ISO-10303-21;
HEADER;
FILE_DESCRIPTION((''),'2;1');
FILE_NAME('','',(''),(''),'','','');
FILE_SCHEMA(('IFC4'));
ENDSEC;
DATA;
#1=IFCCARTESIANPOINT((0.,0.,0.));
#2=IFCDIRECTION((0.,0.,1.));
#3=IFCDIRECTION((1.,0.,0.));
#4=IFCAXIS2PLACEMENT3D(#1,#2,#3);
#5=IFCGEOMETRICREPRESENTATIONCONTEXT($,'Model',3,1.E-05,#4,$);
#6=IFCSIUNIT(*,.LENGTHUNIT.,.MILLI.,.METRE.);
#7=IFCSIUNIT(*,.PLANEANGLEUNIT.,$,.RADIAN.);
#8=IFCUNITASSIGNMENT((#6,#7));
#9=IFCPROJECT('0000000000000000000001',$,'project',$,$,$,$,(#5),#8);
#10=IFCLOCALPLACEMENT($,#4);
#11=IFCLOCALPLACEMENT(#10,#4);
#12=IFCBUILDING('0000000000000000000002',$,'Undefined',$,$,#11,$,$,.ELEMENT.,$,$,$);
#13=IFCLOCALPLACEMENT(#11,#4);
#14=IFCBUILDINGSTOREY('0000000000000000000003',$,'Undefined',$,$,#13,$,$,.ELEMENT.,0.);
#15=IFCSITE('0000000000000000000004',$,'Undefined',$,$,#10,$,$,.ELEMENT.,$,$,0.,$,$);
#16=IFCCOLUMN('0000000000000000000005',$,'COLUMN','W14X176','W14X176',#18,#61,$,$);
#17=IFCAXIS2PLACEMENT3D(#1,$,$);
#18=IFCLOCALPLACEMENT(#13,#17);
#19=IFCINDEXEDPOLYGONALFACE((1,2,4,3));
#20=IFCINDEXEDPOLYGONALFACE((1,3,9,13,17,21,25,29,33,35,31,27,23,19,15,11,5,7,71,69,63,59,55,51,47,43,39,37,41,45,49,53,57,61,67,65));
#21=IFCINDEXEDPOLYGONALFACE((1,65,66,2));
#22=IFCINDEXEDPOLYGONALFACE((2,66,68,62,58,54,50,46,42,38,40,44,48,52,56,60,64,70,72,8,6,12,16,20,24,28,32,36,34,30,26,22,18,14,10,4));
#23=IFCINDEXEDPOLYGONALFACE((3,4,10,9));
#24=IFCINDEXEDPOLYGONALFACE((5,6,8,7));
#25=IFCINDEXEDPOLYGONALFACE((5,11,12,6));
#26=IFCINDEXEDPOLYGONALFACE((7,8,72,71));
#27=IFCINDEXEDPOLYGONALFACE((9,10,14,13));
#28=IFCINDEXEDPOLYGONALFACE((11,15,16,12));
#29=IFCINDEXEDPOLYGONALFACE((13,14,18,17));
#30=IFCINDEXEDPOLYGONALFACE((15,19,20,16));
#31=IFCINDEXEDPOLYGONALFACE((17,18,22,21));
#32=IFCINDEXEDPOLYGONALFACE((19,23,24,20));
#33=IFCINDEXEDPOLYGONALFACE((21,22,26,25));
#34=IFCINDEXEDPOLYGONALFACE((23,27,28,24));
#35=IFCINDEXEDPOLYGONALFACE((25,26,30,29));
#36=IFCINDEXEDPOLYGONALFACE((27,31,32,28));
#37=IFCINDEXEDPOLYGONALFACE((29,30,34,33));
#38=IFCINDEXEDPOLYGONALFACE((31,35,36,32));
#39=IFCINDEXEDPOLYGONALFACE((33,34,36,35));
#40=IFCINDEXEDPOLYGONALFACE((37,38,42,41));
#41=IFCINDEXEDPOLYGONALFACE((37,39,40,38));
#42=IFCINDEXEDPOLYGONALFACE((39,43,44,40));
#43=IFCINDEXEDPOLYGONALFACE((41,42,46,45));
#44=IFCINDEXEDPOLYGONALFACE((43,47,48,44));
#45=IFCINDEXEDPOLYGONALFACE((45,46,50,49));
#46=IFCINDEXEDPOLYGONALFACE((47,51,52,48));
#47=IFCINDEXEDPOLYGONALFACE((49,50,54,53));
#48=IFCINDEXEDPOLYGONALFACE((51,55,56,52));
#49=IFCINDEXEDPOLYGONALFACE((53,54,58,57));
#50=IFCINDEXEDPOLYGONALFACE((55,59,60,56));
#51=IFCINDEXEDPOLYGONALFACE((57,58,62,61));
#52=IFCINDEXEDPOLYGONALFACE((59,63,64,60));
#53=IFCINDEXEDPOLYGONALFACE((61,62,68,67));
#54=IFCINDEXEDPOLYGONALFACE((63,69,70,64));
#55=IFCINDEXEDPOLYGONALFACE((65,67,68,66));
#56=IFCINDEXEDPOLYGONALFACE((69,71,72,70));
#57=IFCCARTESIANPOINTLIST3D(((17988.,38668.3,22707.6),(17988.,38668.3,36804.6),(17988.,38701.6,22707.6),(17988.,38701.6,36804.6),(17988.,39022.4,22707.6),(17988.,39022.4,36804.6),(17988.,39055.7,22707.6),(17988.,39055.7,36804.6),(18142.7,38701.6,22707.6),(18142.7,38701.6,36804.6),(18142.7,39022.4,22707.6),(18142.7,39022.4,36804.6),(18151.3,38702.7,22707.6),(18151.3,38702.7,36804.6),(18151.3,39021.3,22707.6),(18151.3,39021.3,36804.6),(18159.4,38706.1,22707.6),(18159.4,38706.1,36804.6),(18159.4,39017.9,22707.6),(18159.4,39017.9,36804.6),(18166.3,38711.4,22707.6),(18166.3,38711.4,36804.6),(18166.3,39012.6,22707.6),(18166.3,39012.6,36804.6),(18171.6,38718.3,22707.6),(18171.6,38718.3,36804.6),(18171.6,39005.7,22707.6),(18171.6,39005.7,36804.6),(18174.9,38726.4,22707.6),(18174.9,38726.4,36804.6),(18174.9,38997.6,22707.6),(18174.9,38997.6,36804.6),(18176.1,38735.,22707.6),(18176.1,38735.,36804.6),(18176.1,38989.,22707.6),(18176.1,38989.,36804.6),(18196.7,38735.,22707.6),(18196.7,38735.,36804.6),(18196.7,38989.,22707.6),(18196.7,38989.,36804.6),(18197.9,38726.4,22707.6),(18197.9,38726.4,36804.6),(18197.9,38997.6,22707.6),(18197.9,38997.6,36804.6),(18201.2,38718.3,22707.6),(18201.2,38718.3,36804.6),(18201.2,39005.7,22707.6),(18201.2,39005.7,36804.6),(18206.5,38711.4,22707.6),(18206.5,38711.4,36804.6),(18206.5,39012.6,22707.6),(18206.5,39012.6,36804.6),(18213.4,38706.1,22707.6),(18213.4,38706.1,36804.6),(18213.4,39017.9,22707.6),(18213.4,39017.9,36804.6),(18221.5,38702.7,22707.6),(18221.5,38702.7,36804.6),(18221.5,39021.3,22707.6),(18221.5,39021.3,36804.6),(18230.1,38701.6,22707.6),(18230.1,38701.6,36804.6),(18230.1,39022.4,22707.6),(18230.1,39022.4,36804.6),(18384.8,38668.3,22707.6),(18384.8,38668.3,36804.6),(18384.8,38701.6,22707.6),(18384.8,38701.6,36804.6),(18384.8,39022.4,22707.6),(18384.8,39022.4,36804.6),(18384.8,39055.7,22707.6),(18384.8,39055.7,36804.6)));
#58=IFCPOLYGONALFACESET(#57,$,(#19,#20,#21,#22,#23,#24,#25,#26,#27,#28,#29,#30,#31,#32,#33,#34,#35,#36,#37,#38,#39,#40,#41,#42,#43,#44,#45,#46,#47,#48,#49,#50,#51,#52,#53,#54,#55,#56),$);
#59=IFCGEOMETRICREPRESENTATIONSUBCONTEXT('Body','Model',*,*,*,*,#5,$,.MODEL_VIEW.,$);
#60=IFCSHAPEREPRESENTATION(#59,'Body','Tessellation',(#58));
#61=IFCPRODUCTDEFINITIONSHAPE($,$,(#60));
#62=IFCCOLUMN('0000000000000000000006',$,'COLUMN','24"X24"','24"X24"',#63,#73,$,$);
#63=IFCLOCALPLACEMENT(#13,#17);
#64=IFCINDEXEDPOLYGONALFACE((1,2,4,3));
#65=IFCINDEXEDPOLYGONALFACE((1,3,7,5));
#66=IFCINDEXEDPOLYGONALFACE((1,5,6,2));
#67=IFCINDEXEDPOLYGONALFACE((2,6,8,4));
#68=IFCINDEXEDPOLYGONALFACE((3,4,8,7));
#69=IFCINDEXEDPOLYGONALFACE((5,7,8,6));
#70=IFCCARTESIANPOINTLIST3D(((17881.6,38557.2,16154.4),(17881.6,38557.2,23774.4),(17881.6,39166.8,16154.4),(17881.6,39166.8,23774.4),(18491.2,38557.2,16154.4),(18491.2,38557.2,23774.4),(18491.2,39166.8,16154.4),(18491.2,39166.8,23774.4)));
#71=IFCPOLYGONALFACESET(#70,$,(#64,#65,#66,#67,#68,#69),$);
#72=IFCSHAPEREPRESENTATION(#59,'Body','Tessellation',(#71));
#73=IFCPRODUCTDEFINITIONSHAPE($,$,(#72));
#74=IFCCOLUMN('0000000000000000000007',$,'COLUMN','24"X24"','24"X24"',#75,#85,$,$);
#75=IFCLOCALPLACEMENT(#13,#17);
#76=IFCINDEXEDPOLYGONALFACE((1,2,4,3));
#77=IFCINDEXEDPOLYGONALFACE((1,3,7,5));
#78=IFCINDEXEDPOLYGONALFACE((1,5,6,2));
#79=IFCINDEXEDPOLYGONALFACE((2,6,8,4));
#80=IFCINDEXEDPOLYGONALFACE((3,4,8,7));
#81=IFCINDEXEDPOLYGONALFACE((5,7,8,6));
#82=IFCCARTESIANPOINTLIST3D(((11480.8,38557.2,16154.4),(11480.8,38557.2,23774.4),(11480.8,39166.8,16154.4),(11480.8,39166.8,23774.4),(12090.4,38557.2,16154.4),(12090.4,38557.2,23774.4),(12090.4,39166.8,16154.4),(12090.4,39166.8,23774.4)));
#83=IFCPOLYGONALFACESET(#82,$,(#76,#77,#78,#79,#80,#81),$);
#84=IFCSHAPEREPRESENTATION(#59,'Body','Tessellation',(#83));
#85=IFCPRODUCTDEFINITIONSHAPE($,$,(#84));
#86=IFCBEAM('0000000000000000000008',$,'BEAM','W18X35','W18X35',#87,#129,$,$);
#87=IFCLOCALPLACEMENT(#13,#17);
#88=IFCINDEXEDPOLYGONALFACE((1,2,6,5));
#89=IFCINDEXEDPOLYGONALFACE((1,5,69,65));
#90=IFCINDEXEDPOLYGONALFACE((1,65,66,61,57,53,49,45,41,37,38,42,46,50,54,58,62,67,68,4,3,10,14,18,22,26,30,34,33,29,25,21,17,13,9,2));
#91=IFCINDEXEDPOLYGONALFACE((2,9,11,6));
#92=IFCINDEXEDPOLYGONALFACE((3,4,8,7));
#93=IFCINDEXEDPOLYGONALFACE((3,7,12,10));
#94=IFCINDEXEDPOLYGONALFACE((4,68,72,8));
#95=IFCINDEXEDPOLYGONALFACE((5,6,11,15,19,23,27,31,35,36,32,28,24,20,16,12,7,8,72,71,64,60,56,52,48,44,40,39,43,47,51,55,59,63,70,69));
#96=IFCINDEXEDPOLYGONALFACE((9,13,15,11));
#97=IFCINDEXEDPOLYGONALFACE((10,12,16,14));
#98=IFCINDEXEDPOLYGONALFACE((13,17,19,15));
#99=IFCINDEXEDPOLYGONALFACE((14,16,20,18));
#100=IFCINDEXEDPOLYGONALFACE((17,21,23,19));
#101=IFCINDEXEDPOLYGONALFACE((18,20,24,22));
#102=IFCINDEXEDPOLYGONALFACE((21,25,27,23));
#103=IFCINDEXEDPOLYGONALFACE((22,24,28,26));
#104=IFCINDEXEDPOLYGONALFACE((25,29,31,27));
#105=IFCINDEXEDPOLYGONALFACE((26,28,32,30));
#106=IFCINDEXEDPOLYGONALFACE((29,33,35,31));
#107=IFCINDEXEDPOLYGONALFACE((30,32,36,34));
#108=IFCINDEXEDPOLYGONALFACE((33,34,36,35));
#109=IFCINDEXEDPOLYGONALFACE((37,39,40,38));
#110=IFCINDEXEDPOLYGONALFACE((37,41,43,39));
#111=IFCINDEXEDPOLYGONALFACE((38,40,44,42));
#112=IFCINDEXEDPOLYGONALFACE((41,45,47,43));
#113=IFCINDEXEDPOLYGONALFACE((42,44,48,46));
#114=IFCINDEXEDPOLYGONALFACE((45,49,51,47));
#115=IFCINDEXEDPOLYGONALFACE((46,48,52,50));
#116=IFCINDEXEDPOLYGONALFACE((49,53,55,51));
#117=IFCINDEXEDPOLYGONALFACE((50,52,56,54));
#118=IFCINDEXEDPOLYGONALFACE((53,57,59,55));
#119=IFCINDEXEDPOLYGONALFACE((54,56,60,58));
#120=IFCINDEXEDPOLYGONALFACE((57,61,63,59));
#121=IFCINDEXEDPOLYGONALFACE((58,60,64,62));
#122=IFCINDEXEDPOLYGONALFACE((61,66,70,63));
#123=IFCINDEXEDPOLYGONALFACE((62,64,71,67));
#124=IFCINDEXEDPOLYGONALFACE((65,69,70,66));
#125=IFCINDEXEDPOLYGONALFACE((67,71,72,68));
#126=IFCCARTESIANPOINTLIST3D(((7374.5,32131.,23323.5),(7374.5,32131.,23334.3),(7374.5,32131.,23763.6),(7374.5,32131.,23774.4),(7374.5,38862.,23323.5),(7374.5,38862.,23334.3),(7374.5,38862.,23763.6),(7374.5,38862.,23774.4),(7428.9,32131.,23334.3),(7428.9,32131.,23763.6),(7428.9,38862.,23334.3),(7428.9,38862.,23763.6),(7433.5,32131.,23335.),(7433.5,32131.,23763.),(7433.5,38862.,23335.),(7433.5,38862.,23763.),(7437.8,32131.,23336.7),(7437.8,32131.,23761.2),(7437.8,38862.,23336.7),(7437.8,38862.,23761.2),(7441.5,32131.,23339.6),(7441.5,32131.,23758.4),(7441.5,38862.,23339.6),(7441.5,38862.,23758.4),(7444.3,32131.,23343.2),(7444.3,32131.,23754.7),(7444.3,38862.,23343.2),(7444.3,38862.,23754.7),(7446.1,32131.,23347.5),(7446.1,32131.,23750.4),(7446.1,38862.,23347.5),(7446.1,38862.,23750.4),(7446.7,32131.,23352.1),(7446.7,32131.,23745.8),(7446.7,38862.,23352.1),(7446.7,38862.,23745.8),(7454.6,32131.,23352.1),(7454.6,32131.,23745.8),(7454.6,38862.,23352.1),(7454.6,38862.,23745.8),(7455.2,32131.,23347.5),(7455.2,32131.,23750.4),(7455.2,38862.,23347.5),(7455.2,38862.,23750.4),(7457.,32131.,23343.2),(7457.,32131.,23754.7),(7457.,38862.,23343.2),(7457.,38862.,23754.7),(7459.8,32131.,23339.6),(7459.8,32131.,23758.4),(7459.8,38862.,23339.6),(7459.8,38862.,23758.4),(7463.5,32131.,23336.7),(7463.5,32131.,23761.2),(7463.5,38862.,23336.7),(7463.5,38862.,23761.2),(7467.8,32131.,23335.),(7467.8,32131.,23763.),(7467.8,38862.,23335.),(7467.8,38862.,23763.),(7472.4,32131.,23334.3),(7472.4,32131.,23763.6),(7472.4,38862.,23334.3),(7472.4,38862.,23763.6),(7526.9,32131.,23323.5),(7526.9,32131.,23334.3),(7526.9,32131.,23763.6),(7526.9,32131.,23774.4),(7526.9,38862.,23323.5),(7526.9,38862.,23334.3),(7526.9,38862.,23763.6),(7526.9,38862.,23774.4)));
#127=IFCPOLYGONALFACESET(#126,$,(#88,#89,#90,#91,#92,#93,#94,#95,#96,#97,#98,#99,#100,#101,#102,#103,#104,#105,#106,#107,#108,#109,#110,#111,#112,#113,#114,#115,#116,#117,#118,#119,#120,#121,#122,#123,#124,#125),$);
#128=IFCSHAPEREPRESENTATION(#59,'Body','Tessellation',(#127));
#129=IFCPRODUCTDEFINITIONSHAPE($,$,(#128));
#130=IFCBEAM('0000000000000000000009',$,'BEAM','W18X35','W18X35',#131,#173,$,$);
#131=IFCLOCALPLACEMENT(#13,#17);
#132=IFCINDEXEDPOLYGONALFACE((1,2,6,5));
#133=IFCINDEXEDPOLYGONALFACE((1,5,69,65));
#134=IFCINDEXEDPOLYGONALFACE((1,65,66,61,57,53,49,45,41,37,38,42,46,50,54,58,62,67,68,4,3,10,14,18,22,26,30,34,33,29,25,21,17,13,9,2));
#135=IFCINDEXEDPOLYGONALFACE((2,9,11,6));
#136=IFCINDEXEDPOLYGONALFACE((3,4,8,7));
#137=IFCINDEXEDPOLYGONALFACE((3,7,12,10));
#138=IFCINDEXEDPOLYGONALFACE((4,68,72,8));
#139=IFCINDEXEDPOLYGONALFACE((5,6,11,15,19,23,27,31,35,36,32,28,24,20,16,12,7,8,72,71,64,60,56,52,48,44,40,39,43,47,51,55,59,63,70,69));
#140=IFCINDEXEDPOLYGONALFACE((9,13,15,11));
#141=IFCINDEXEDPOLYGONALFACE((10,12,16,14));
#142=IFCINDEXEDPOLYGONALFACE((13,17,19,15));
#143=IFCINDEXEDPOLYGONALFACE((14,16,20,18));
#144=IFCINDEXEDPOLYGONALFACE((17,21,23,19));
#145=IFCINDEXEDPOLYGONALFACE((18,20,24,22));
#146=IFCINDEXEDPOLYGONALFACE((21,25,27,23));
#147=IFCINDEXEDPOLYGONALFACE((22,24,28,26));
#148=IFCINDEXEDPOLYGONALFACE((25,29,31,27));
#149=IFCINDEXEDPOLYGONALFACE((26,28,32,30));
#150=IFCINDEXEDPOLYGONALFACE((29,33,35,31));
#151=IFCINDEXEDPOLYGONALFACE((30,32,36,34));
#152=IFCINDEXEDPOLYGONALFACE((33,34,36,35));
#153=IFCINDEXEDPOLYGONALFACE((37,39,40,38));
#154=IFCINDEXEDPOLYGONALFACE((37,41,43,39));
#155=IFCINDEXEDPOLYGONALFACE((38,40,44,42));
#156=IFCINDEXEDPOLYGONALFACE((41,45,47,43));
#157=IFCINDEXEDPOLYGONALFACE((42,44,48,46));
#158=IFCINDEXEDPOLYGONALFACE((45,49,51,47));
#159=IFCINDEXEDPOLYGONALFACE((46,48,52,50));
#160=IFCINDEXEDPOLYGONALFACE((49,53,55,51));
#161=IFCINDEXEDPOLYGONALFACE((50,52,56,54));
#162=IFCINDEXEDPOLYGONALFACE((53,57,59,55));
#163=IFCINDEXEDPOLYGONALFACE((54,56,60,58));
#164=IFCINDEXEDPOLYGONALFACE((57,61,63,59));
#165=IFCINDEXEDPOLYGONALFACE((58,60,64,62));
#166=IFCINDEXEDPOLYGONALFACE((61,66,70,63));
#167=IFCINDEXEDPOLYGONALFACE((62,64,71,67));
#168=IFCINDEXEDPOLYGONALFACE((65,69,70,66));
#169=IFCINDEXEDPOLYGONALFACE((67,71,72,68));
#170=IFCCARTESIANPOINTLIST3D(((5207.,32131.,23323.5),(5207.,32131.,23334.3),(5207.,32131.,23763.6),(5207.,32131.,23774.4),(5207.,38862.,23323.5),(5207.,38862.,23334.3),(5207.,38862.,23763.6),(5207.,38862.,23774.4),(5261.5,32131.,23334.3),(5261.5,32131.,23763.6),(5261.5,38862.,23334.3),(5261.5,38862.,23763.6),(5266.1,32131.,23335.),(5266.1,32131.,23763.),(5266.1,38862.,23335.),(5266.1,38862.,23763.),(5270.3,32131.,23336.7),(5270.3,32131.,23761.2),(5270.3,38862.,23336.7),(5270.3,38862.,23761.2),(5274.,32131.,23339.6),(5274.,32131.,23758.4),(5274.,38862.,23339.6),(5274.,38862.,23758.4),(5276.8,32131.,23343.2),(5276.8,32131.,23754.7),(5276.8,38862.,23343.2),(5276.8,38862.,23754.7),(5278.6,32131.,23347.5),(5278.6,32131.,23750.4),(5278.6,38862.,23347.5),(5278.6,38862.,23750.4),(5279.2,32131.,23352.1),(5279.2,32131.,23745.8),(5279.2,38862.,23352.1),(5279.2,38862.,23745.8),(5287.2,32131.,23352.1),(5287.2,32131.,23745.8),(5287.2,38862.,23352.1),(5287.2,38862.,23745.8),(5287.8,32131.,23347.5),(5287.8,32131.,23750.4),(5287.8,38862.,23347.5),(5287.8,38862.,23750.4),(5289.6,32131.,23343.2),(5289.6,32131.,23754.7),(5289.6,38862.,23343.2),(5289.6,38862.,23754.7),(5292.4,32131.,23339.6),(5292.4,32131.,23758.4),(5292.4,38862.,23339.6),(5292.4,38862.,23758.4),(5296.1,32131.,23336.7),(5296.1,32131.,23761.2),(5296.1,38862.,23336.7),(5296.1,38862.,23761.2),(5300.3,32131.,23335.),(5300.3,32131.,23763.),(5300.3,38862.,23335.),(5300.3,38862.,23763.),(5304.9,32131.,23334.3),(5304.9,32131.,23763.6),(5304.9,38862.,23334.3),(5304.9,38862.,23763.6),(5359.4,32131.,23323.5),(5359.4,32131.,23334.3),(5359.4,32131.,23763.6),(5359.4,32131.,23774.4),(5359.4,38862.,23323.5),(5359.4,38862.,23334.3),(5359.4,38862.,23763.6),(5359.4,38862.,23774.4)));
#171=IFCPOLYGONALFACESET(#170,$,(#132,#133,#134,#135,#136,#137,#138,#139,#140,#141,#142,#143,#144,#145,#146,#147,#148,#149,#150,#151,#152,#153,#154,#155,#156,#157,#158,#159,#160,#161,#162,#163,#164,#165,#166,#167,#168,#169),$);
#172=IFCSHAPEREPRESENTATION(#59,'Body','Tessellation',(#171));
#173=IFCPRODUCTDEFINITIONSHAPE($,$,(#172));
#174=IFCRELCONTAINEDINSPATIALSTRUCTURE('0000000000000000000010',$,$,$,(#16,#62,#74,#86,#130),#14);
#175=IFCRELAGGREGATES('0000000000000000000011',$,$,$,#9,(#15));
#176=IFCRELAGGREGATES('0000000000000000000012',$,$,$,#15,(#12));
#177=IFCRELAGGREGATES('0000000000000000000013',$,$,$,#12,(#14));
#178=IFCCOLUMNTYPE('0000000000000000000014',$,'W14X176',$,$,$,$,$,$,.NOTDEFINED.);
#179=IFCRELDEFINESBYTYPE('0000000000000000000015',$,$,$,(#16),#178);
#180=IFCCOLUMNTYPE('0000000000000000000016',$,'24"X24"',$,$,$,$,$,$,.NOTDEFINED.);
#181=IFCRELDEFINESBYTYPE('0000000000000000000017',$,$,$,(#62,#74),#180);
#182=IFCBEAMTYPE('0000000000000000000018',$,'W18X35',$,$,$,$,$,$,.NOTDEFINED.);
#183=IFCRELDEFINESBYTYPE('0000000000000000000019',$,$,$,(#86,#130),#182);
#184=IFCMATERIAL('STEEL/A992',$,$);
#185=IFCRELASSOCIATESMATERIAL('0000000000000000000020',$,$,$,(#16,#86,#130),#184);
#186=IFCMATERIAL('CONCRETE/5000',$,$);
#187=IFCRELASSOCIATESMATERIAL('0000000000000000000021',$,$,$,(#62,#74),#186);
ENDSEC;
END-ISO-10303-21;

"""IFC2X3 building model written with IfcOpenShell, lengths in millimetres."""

from ifc_helpers import new_model, si_unit, frame, origin_with_axes, origin_2d_with_axis, place, context, subcontext, project, spatial, rectangle, i_section, extrude, material, type_object, element, save


model = new_model("IFC2X3")

# Units and contexts
model_context = context("Model", 3, precision=1e-05, world=origin_with_axes())
body_context = subcontext(model_context, "Body", "Model", "MODEL_VIEW")
ifc_project = project(units=[si_unit("LENGTHUNIT", "METRE", prefix="MILLI"), si_unit("PLANEANGLEUNIT", "RADIAN")], contexts=[model_context])

# Site, building, storey
site_placement = place(None, origin_with_axes())
site = spatial("IfcSite", under=ifc_project, at=site_placement, Name="Undefined", CompositionType="ELEMENT", RefElevation=0.0)
building_placement = place(site_placement, origin_with_axes())
building = spatial("IfcBuilding", under=site, at=building_placement, Name="Undefined", CompositionType="ELEMENT")
storey_placement = place(building_placement, origin_with_axes())
storey = spatial("IfcBuildingStorey", under=building, at=storey_placement, Name="Undefined", CompositionType="ELEMENT", Elevation=0.0)

# Columns
ifc_material_1 = material(Name="STEEL/A992")
column_type_1 = type_object("IfcColumnType", Name="W14X176", PredefinedType="NOTDEFINED")
column_1_placement = place(storey_placement, frame((18186.4, 38862.0, 22707.6), z_axis=(0.0, 0.0, 1.0), x_axis=(1.0, 0.0, 0.0)))
element("IfcColumn", 1, at=column_1_placement, inside=storey, type_object=column_type_1, material=ifc_material_1, Name="COLUMN", Description="W14X176", ObjectType="W14X176", context=body_context, shape_type="SweptSolid", body=[
    extrude(i_section(OverallWidth=396.9, OverallDepth=387.4, WebThickness=20.6, FlangeThickness=33.3, FilletRadius=33.4, at=origin_2d_with_axis()), frame((0.0, 0.0, 14097.0), z_axis=(0.0, 0.0, -1.0), x_axis=(-1.0, 0.0, 0.0)), (0.0, 0.0, 1.0), 14097.0),
])
ifc_material_2 = material(Name="CONCRETE/5000")
column_type_2 = type_object("IfcColumnType", Name="24\"X24\"", PredefinedType="NOTDEFINED")
for number, where, z_axis, x_axis, name in (
    (2, (18186.4, 38862.0, 16154.4), (0.0, 0.0, 1.0), (1.0, 0.0, 0.0), "COLUMN"),
    (3, (11785.6, 38862.0, 16154.4), (0.0, 0.0, 1.0), (1.0, 0.0, 0.0), "COLUMN"),
):
    element("IfcColumn", number, at=place(storey_placement, frame(where, z_axis=z_axis, x_axis=x_axis)), inside=storey, type_object=column_type_2, material=ifc_material_2, Name=name, Description="24\"X24\"", ObjectType="24\"X24\"", context=body_context, shape_type="SweptSolid", body=[
        extrude(rectangle(XDim=609.6, YDim=609.6, at=origin_2d_with_axis()), frame((0.0, 0.0, 7620.0), z_axis=(0.0, 0.0, -1.0), x_axis=(0.0, -1.0, 0.0)), (0.0, 0.0, 1.0), 7620.0),
    ])

# Beams
beam_type_1 = type_object("IfcBeamType", Name="W18X35", PredefinedType="NOTDEFINED")
for number, where, z_axis, x_axis, name in (
    (4, (7450.7, 32131.0, 23549.0), (0.0, 0.0, 1.0), (0.0, 1.0, 0.0), "BEAM"),
    (5, (5283.2, 32131.0, 23549.0), (0.0, 0.0, 1.0), (0.0, 1.0, 0.0), "BEAM"),
):
    element("IfcBeam", number, at=place(storey_placement, frame(where, z_axis=z_axis, x_axis=x_axis)), inside=storey, type_object=beam_type_1, material=ifc_material_1, Name=name, Description="W18X35", ObjectType="W18X35", context=body_context, shape_type="SweptSolid", body=[
        extrude(i_section(OverallWidth=152.4, OverallDepth=450.9, WebThickness=7.9, FlangeThickness=10.8, FilletRadius=17.8, at=origin_2d_with_axis()), frame((6731.0, 0.0, 0.0), z_axis=(-1.0, 0.0, 0.0), x_axis=(0.0, -1.0, 0.0)), (0.0, 0.0, 1.0), 6731.0),
    ])

save(model, "model.ifc")
